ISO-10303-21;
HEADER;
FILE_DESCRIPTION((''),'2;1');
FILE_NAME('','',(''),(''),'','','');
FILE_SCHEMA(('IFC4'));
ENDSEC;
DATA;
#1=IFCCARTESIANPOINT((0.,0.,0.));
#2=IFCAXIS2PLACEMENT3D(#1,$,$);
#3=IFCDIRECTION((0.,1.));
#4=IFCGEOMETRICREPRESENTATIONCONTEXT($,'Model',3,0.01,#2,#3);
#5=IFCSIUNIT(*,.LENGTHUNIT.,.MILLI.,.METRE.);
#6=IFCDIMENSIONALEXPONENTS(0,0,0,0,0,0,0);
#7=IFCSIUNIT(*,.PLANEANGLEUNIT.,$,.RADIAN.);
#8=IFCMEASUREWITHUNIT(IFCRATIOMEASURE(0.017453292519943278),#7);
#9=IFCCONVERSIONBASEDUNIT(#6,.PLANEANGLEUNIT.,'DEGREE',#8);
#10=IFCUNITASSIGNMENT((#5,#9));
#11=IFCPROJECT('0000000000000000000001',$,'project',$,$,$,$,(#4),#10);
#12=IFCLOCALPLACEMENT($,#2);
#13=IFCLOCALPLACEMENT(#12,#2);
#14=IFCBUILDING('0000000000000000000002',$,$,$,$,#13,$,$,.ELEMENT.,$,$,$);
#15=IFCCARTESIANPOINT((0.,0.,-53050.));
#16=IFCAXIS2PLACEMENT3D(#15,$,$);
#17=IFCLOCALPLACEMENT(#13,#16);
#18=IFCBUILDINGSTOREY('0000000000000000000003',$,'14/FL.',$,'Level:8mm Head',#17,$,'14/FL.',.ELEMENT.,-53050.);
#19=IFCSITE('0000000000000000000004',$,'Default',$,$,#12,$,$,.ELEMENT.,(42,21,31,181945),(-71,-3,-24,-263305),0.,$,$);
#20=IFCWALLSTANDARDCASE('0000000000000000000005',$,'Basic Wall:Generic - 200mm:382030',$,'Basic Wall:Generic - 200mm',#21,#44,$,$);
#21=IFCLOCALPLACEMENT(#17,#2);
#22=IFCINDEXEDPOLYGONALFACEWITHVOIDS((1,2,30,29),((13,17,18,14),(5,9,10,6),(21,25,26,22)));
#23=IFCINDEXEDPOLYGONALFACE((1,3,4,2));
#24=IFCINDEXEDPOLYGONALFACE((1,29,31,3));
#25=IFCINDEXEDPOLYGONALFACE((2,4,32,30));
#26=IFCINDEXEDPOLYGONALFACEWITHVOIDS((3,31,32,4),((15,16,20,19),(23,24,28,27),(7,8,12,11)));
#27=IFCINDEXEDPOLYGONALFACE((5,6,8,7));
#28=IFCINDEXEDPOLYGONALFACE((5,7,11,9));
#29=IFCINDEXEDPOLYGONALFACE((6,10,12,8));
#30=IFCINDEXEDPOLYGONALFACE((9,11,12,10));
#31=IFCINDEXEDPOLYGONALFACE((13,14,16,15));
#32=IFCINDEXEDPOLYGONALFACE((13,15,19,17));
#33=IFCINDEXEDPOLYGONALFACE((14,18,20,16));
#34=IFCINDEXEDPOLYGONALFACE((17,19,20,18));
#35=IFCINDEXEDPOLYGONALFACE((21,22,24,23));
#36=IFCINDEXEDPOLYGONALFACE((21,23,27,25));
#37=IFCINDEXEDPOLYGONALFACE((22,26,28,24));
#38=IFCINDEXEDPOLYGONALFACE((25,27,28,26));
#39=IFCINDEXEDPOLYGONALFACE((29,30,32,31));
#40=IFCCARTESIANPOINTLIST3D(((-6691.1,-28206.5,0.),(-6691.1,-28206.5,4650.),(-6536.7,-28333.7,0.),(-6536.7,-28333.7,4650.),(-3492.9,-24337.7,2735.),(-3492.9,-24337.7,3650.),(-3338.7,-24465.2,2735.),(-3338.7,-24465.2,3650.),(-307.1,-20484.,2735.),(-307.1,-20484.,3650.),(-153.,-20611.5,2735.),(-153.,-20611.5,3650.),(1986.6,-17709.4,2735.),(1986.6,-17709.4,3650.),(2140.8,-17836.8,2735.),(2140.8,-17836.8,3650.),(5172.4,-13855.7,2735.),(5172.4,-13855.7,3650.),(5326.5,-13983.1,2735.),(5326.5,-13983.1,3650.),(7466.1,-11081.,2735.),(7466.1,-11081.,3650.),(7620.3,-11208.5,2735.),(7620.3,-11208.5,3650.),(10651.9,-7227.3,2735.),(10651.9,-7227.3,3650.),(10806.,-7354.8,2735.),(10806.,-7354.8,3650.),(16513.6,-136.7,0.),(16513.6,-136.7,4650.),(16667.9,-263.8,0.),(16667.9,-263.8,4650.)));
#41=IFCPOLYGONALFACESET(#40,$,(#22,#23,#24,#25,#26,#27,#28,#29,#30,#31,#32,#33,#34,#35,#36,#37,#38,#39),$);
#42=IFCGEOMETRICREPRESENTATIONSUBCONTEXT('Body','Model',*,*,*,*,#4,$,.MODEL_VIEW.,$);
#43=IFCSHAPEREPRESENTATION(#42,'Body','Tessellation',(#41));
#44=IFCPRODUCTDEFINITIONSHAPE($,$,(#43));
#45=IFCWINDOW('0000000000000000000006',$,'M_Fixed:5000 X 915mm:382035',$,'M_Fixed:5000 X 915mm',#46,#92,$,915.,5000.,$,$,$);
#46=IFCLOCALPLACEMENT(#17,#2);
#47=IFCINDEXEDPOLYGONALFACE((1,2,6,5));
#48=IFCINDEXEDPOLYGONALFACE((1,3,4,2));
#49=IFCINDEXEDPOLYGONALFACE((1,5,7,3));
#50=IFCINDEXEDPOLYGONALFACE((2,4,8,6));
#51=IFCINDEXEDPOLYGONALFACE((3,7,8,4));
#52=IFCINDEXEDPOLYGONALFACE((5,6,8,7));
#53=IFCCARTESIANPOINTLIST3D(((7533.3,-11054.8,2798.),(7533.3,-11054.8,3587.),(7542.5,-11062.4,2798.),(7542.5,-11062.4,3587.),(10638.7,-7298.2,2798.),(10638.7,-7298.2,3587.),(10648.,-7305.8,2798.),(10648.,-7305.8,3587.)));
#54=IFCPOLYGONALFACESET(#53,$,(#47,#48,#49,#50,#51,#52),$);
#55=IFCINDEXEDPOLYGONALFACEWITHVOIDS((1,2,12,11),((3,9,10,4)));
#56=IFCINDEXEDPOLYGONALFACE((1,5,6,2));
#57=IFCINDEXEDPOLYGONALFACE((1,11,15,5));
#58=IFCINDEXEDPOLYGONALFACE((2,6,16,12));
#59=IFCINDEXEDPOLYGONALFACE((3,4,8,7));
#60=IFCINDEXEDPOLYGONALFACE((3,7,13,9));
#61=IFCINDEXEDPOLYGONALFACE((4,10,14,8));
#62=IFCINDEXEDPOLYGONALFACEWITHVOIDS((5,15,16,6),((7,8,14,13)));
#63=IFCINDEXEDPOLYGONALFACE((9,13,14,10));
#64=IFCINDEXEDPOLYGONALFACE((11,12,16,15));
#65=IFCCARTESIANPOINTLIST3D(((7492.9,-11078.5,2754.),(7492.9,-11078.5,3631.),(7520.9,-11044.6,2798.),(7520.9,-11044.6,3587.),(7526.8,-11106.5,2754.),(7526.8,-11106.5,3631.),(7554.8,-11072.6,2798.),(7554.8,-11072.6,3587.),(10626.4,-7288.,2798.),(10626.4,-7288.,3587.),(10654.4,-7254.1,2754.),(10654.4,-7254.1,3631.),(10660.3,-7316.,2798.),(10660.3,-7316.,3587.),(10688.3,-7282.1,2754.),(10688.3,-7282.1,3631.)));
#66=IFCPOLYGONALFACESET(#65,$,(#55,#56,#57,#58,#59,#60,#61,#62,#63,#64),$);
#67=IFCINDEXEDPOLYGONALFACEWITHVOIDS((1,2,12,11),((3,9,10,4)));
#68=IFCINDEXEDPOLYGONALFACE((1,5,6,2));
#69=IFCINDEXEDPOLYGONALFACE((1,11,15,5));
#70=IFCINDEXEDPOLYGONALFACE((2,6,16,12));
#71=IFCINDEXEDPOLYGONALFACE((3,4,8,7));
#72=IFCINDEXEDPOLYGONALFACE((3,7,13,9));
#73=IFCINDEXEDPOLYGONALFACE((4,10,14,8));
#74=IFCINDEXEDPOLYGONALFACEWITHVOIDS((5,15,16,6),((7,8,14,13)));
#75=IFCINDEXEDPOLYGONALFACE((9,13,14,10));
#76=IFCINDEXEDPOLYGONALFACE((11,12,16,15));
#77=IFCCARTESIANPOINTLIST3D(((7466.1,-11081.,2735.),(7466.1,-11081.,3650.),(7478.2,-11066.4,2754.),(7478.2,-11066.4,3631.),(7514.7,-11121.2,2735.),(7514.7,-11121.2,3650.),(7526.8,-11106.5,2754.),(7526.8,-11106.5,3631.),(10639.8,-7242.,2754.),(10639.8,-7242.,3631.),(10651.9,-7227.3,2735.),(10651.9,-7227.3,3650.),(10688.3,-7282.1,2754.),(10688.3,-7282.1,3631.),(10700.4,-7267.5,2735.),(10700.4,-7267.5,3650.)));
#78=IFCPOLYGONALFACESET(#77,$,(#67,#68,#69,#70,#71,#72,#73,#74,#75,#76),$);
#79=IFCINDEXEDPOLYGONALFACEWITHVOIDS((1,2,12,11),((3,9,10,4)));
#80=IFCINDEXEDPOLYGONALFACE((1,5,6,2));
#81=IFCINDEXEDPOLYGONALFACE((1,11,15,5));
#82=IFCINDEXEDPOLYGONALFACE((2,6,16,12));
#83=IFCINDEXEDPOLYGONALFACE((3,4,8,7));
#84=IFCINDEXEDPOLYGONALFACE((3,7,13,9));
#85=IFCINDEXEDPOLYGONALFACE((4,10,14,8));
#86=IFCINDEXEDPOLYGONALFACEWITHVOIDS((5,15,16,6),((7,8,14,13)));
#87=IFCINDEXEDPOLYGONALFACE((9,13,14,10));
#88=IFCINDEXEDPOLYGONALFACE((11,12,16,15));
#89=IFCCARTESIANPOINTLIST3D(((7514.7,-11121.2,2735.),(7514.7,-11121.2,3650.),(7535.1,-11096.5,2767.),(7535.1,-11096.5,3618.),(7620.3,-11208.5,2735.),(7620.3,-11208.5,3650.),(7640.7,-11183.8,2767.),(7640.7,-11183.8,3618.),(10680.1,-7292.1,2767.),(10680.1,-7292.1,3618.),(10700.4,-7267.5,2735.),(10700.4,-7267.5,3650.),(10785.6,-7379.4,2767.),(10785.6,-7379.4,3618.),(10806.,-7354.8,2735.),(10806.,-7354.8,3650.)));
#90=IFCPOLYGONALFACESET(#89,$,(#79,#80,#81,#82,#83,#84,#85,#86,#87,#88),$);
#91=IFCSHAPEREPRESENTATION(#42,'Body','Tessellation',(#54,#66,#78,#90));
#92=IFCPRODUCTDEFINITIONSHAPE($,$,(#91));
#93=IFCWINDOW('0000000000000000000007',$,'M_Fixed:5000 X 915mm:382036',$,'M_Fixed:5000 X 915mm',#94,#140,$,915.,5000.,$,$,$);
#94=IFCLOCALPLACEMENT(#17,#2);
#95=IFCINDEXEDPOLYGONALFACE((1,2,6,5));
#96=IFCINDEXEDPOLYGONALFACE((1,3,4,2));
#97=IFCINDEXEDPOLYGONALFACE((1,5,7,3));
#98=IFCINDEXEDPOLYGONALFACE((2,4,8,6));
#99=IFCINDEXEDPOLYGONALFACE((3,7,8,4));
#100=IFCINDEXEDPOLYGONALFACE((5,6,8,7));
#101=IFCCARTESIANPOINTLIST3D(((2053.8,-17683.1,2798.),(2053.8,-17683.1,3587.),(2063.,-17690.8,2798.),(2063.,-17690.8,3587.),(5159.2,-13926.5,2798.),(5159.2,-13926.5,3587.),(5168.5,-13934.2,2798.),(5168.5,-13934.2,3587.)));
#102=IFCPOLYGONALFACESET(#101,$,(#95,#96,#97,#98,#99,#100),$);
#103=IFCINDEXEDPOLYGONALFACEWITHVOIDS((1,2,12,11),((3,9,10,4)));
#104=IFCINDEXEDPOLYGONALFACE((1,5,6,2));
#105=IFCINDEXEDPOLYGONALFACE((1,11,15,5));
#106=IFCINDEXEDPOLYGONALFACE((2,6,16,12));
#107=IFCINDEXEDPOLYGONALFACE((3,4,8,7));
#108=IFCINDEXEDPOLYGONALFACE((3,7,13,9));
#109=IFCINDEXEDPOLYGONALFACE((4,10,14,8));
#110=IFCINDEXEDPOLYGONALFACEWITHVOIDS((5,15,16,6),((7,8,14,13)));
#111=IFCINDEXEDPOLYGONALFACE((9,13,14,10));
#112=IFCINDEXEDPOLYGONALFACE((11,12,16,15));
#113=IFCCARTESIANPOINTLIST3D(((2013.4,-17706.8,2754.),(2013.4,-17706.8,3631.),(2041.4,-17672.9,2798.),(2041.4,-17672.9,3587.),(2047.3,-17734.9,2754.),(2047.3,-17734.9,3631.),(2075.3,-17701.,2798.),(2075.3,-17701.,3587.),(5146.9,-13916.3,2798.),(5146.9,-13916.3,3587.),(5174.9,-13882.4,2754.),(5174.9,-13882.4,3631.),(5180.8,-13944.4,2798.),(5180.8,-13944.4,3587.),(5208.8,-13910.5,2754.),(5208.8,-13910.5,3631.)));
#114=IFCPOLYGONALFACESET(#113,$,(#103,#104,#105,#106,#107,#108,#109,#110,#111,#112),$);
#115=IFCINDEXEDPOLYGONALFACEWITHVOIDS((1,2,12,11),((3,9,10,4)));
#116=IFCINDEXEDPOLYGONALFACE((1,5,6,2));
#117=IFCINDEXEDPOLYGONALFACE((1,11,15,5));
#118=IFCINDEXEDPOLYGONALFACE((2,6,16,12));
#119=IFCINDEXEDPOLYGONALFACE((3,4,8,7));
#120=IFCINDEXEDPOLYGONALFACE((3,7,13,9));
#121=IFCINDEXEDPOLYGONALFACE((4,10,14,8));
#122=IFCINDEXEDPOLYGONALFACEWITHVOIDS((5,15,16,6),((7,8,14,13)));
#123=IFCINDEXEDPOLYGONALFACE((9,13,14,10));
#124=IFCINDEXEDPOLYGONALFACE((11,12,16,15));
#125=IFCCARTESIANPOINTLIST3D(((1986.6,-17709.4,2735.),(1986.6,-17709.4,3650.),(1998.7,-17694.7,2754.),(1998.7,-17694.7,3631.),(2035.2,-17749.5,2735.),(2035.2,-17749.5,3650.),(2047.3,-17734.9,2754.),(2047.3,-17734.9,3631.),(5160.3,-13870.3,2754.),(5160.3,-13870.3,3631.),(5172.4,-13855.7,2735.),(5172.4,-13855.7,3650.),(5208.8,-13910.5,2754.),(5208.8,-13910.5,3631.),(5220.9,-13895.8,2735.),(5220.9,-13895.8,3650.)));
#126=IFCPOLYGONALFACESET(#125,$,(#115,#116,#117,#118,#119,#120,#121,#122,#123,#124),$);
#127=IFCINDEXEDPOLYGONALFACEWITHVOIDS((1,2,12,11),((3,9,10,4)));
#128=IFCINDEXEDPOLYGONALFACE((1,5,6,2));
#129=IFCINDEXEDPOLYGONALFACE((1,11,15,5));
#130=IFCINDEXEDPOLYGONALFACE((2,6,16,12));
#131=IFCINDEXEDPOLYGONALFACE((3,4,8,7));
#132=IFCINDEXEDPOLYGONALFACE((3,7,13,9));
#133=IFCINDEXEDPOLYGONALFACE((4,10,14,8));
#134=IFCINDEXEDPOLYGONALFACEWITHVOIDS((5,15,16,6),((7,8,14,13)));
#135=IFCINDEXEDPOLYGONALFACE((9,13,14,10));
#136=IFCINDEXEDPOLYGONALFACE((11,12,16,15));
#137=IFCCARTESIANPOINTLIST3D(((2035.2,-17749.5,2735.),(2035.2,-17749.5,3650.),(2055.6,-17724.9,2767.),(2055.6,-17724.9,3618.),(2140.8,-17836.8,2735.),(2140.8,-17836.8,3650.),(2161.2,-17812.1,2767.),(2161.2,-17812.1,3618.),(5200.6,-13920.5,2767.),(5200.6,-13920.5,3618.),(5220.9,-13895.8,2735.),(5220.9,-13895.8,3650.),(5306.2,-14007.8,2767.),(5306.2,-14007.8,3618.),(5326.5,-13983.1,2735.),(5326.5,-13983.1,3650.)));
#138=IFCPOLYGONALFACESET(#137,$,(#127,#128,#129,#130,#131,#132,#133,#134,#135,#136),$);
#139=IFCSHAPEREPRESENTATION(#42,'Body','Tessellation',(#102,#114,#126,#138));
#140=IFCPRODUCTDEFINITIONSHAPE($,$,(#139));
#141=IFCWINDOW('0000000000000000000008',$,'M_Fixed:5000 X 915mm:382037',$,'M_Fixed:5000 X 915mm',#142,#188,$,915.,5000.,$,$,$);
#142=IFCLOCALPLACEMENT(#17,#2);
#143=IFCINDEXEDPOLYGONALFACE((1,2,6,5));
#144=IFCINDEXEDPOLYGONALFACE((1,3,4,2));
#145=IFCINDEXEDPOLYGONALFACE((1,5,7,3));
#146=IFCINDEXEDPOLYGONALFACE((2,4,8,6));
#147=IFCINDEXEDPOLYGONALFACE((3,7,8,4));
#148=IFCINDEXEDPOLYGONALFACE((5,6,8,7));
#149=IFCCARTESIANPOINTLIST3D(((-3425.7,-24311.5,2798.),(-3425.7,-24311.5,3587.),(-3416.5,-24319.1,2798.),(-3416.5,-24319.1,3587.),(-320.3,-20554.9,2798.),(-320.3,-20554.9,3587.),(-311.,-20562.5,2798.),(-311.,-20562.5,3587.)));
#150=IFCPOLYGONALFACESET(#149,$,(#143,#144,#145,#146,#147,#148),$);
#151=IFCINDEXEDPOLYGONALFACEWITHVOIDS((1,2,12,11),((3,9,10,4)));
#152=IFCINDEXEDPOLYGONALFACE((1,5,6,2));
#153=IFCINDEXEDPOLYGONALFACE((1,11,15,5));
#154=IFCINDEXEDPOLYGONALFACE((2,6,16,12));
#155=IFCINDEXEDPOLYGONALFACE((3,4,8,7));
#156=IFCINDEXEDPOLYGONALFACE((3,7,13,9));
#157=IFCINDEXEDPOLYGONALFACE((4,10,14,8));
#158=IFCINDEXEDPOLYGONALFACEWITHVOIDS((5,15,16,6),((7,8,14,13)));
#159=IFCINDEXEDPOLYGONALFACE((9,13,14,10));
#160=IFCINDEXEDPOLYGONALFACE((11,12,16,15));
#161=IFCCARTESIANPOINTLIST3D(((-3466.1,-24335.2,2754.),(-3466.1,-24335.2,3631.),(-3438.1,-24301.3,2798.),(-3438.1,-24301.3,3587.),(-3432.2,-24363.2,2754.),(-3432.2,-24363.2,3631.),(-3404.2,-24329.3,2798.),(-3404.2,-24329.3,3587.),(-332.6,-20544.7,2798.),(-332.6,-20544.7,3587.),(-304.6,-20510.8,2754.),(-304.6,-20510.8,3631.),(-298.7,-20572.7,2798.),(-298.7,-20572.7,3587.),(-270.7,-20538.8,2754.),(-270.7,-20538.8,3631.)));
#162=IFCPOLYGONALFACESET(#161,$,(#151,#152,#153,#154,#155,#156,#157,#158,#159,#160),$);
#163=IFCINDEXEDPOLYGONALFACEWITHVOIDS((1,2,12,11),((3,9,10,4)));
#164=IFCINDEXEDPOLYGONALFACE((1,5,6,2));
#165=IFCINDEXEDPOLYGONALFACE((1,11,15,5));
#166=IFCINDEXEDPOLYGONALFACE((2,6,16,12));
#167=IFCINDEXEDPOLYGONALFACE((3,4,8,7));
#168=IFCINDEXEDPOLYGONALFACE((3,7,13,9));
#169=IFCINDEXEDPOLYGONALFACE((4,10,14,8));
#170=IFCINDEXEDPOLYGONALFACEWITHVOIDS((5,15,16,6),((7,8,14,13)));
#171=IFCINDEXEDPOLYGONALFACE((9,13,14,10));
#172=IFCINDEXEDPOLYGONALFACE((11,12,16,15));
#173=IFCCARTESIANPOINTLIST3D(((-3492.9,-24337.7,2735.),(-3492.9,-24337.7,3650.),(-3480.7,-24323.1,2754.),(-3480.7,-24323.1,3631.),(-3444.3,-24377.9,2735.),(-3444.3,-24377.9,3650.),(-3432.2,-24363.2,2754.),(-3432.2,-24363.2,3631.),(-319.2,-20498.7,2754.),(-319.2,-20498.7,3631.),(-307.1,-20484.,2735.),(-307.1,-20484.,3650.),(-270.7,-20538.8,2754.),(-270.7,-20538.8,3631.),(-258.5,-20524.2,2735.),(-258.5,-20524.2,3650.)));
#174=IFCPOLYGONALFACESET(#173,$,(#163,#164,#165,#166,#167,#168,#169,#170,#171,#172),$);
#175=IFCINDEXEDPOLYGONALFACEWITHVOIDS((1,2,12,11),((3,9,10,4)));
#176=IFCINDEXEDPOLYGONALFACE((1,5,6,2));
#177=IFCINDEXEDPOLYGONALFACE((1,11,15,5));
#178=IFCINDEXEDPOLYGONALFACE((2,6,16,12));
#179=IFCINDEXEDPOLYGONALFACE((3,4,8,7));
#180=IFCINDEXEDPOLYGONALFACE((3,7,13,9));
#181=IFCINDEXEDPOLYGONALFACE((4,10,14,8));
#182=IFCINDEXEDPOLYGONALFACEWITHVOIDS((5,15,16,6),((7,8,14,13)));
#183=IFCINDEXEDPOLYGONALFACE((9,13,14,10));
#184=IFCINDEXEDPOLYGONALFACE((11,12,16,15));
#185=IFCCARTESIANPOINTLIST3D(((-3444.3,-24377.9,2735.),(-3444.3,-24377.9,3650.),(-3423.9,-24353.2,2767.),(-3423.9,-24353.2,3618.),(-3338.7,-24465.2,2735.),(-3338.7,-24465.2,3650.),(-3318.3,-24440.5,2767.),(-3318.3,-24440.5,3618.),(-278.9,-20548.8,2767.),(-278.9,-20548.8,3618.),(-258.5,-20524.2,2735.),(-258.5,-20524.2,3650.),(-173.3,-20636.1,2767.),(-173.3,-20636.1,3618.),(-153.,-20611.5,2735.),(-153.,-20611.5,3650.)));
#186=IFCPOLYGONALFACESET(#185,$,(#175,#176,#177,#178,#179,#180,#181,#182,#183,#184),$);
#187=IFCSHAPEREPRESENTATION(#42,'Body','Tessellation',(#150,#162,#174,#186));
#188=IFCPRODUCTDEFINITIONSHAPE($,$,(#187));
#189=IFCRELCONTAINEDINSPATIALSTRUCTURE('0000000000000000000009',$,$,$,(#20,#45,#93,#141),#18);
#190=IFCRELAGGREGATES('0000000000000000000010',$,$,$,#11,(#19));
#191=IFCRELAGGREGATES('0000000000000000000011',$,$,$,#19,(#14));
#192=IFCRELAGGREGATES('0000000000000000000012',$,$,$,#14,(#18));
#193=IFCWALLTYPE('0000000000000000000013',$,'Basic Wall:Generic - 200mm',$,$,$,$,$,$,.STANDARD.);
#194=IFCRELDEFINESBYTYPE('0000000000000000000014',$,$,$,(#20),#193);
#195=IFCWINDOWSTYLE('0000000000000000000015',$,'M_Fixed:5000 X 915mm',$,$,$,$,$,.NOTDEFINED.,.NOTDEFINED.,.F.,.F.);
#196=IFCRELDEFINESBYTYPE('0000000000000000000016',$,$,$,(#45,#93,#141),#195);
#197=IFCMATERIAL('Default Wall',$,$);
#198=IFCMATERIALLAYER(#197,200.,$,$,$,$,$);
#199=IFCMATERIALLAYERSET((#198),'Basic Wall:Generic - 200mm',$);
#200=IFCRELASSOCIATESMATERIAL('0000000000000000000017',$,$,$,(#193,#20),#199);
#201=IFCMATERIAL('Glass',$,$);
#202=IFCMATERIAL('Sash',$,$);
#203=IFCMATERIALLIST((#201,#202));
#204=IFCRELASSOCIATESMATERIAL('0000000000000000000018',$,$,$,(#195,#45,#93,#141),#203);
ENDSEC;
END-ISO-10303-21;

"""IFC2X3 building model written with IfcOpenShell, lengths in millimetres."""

from ifc_helpers import new_model, entity, si_unit, converted_unit, direction, frame, frame_2d, origin, place, context, subcontext, project, spatial, polyline, rectangle, outline, extrude, source, transform, mapped, material, material_list, layer, layer_set, layer_usage, type_object, type_shapes, element, fill, save


model = new_model("IFC2X3")

# Units and contexts
model_context = context("Model", 3, precision=0.01, world=origin(), true_north=direction((0.0, 1.0)))
body_context = subcontext(model_context, "Body", "Model", "MODEL_VIEW")
ifc_project = project(units=[si_unit("LENGTHUNIT", "METRE", prefix="MILLI"), converted_unit("PLANEANGLEUNIT", "DEGREE", entity("IfcRatioMeasure", 0.017453292519943278), si_unit("PLANEANGLEUNIT", "RADIAN"), dimensions=[0, 0, 0, 0, 0, 0, 0])], contexts=[model_context])

# Site, building, storey
site_placement = place(None, origin())
site = spatial("IfcSite", under=ifc_project, at=site_placement, Name="Default", CompositionType="ELEMENT", RefLatitude=(42, 21, 31, 181945), RefLongitude=(-71, -3, -24, -263305), RefElevation=0.0)
building_placement = place(site_placement, origin())
building = spatial("IfcBuilding", under=site, at=building_placement, CompositionType="ELEMENT")
storey_placement = place(building_placement, frame((0.0, 0.0, -53050.0)))
storey = spatial("IfcBuildingStorey", under=building, at=storey_placement, Name="14/FL.", ObjectType="Level:8mm Head", LongName="14/FL.", CompositionType="ELEMENT", Elevation=-53050.0)

# Shared definitions
ifc_material_1 = material(Name="Default Wall")
ifc_layer = layer(ifc_material_1, 200.0)
ifc_layer_set = layer_set([ifc_layer], Name="Basic Wall:Generic - 200mm")
ifc_layer_usage = layer_usage(ifc_layer_set, "AXIS2", "NEGATIVE", 100.0)
wall_type = type_object("IfcWallType", Name="Basic Wall:Generic - 200mm", PredefinedType="STANDARD", material=ifc_layer_set)

# Wall, openings, windows
wall_1_placement = place(storey_placement, frame((17100.6, 416.5, 0.0), z_axis=(0.0, 0.0, 1.0), x_axis=(-0.63715, -0.770739, 0.0)))
wall_1 = element("IfcWallStandardCase", 1, at=wall_1_placement, inside=storey, type_object=wall_type, material=ifc_layer_usage, Name="Basic Wall:Generic - 200mm:382030", ObjectType="Basic Wall:Generic - 200mm", context=body_context, shape_type="SweptSolid", body=[
    extrude(outline(polyline([(37219.8, -100.0), (37219.4, 100.0), (37019.4, 100.0), (800.0, 100.0), (800.4, -100.0), (37219.8, -100.0)])), origin(), (0.0, 0.0, 1.0), 4650.0),
])
opening_1_placement = place(wall_1_placement, origin())
element("IfcOpeningElement", 2, at=opening_1_placement, cuts=wall_1, ObjectType="Opening", context=body_context, shape_type="SweptSolid", body=[
    extrude(rectangle(XDim=1000.0, YDim=1012.7, at=frame_2d((0.0, 0.0), x_axis=(1.0, 0.0))), frame((294.2, -182.6, 500.0), z_axis=(-0.00185, 0.999998, 0.0), x_axis=(0.0, 0.0, -1.0)), (0.0, 0.0, 1.0), 1010.1),
])
opening_2_placement = place(wall_1_placement, frame((15000.2, 100.0, 2735.0)))
opening_2 = element("IfcOpeningElement", 3, at=opening_2_placement, cuts=wall_1, ObjectType="Opening", context=body_context, shape_type="SweptSolid", body=[
    extrude(rectangle(XDim=915.0, YDim=5000.0, at=frame_2d((457.5, 2500.0), x_axis=(1.0, 0.0))), frame((0.0, 0.0, 0.0), z_axis=(0.0, -1.0, 0.0), x_axis=(0.0, 0.0, 1.0)), (0.0, 0.0, 1.0), 200.0),
])
opening_3_placement = place(wall_1_placement, frame((23600.2, 100.0, 2735.0)))
opening_3 = element("IfcOpeningElement", 4, at=opening_3_placement, cuts=wall_1, ObjectType="Opening", context=body_context, shape_type="SweptSolid", body=[
    extrude(rectangle(XDim=915.0, YDim=5000.0, at=frame_2d((457.5, 2500.0), x_axis=(1.0, 0.0))), frame((0.0, 0.0, 0.0), z_axis=(0.0, -1.0, 0.0), x_axis=(0.0, 0.0, 1.0)), (0.0, 0.0, 1.0), 200.0),
])
opening_4_placement = place(wall_1_placement, frame((32200.2, 100.0, 2735.0)))
opening_4 = element("IfcOpeningElement", 5, at=opening_4_placement, cuts=wall_1, ObjectType="Opening", context=body_context, shape_type="SweptSolid", body=[
    extrude(rectangle(XDim=915.0, YDim=5000.0, at=frame_2d((457.5, 2500.0), x_axis=(1.0, 0.0))), frame((0.0, 0.0, 0.0), z_axis=(0.0, -1.0, 0.0), x_axis=(0.0, 0.0, 1.0)), (0.0, 0.0, 1.0), 200.0),
])
ifc_material_2 = material(Name="Glass")
ifc_material_3 = material(Name="Sash")
ifc_material_list = material_list([ifc_material_2, ifc_material_3])
window_style_1 = type_object("IfcWindowStyle", Name="M_Fixed:5000 X 915mm", ConstructionType="NOTDEFINED", OperationType="NOTDEFINED", ParameterTakesPrecedence=False, Sizeable=False, material=ifc_material_list)
shared_shape_1 = source(origin(), body_context, "Body", "SweptSolid", [
    extrude(rectangle(XDim=12.0, YDim=4874.0, at=frame_2d((0.0, 0.0), x_axis=(1.0, 0.0))), frame((2500.0, 159.0, 63.0), z_axis=(0.0, 0.0, 1.0), x_axis=(0.0, -1.0, 0.0)), (0.0, 0.0, 1.0), 789.0),
    extrude(outline(polyline([(-2481.0, -438.5), (2481.0, -438.5), (2481.0, 438.5), (-2481.0, 438.5), (-2481.0, -438.5)]), holes=[polyline([(-2437.0, -394.5), (-2437.0, 394.5), (2437.0, 394.5), (2437.0, -394.5), (-2437.0, -394.5)])]), frame((2500.0, 137.0, 457.5), z_axis=(0.0, 1.0, 0.0), x_axis=(1.0, 0.0, 0.0)), (0.0, 0.0, 1.0), 44.0),
    extrude(outline(polyline([(-2500.0, -457.5), (2500.0, -457.5), (2500.0, 457.5), (-2500.0, 457.5), (-2500.0, -457.5)]), holes=[polyline([(-2481.0, -438.5), (-2481.0, 438.5), (2481.0, 438.5), (2481.0, -438.5), (-2481.0, -438.5)])]), frame((2500.0, 137.0, 457.5), z_axis=(0.0, 1.0, 0.0), x_axis=(1.0, 0.0, 0.0)), (0.0, 0.0, 1.0), 63.0),
    extrude(outline(polyline([(-2500.0, -457.5), (2500.0, -457.5), (2500.0, 457.5), (-2500.0, 457.5), (-2500.0, -457.5)]), holes=[polyline([(-2468.0, -425.5), (-2468.0, 425.5), (2468.0, 425.5), (2468.0, -425.5), (-2468.0, -425.5)])]), frame((2500.0, 0.0, 457.5), z_axis=(0.0, 1.0, 0.0), x_axis=(1.0, 0.0, 0.0)), (0.0, 0.0, 1.0), 137.0),
])
type_shapes(window_style_1, [shared_shape_1])
window_1_placement = place(opening_2_placement, frame((0.0, 0.0, 0.0), z_axis=(0.0, 0.0, 1.0), x_axis=(-1.0, 0.0, 0.0)))
window_1 = element("IfcWindow", 6, at=window_1_placement, inside=storey, type_object=window_style_1, material=ifc_material_list, Name="M_Fixed:5000 X 915mm:382035", ObjectType="M_Fixed:5000 X 915mm", OverallHeight=915.0, OverallWidth=5000.0, context=body_context, shape_type="MappedRepresentation", body=[
    mapped(shared_shape_1, transform((0.0, 0.0, 0.0), scale=1.0)),
])
fill(opening_2, window_1)
window_2_placement = place(opening_3_placement, frame((0.0, 0.0, 0.0), z_axis=(0.0, 0.0, 1.0), x_axis=(-1.0, 0.0, 0.0)))
window_2 = element("IfcWindow", 7, at=window_2_placement, inside=storey, type_object=window_style_1, material=ifc_material_list, Name="M_Fixed:5000 X 915mm:382036", ObjectType="M_Fixed:5000 X 915mm", OverallHeight=915.0, OverallWidth=5000.0, context=body_context, shape_type="MappedRepresentation", body=[
    mapped(shared_shape_1, transform((0.0, 0.0, 0.0), scale=1.0)),
])
fill(opening_3, window_2)
window_3_placement = place(opening_4_placement, frame((0.0, 0.0, 0.0), z_axis=(0.0, 0.0, 1.0), x_axis=(-1.0, 0.0, 0.0)))
window_3 = element("IfcWindow", 8, at=window_3_placement, inside=storey, type_object=window_style_1, material=ifc_material_list, Name="M_Fixed:5000 X 915mm:382037", ObjectType="M_Fixed:5000 X 915mm", OverallHeight=915.0, OverallWidth=5000.0, context=body_context, shape_type="MappedRepresentation", body=[
    mapped(shared_shape_1, transform((0.0, 0.0, 0.0), scale=1.0)),
])
fill(opening_4, window_3)

save(model, "model.ifc")
